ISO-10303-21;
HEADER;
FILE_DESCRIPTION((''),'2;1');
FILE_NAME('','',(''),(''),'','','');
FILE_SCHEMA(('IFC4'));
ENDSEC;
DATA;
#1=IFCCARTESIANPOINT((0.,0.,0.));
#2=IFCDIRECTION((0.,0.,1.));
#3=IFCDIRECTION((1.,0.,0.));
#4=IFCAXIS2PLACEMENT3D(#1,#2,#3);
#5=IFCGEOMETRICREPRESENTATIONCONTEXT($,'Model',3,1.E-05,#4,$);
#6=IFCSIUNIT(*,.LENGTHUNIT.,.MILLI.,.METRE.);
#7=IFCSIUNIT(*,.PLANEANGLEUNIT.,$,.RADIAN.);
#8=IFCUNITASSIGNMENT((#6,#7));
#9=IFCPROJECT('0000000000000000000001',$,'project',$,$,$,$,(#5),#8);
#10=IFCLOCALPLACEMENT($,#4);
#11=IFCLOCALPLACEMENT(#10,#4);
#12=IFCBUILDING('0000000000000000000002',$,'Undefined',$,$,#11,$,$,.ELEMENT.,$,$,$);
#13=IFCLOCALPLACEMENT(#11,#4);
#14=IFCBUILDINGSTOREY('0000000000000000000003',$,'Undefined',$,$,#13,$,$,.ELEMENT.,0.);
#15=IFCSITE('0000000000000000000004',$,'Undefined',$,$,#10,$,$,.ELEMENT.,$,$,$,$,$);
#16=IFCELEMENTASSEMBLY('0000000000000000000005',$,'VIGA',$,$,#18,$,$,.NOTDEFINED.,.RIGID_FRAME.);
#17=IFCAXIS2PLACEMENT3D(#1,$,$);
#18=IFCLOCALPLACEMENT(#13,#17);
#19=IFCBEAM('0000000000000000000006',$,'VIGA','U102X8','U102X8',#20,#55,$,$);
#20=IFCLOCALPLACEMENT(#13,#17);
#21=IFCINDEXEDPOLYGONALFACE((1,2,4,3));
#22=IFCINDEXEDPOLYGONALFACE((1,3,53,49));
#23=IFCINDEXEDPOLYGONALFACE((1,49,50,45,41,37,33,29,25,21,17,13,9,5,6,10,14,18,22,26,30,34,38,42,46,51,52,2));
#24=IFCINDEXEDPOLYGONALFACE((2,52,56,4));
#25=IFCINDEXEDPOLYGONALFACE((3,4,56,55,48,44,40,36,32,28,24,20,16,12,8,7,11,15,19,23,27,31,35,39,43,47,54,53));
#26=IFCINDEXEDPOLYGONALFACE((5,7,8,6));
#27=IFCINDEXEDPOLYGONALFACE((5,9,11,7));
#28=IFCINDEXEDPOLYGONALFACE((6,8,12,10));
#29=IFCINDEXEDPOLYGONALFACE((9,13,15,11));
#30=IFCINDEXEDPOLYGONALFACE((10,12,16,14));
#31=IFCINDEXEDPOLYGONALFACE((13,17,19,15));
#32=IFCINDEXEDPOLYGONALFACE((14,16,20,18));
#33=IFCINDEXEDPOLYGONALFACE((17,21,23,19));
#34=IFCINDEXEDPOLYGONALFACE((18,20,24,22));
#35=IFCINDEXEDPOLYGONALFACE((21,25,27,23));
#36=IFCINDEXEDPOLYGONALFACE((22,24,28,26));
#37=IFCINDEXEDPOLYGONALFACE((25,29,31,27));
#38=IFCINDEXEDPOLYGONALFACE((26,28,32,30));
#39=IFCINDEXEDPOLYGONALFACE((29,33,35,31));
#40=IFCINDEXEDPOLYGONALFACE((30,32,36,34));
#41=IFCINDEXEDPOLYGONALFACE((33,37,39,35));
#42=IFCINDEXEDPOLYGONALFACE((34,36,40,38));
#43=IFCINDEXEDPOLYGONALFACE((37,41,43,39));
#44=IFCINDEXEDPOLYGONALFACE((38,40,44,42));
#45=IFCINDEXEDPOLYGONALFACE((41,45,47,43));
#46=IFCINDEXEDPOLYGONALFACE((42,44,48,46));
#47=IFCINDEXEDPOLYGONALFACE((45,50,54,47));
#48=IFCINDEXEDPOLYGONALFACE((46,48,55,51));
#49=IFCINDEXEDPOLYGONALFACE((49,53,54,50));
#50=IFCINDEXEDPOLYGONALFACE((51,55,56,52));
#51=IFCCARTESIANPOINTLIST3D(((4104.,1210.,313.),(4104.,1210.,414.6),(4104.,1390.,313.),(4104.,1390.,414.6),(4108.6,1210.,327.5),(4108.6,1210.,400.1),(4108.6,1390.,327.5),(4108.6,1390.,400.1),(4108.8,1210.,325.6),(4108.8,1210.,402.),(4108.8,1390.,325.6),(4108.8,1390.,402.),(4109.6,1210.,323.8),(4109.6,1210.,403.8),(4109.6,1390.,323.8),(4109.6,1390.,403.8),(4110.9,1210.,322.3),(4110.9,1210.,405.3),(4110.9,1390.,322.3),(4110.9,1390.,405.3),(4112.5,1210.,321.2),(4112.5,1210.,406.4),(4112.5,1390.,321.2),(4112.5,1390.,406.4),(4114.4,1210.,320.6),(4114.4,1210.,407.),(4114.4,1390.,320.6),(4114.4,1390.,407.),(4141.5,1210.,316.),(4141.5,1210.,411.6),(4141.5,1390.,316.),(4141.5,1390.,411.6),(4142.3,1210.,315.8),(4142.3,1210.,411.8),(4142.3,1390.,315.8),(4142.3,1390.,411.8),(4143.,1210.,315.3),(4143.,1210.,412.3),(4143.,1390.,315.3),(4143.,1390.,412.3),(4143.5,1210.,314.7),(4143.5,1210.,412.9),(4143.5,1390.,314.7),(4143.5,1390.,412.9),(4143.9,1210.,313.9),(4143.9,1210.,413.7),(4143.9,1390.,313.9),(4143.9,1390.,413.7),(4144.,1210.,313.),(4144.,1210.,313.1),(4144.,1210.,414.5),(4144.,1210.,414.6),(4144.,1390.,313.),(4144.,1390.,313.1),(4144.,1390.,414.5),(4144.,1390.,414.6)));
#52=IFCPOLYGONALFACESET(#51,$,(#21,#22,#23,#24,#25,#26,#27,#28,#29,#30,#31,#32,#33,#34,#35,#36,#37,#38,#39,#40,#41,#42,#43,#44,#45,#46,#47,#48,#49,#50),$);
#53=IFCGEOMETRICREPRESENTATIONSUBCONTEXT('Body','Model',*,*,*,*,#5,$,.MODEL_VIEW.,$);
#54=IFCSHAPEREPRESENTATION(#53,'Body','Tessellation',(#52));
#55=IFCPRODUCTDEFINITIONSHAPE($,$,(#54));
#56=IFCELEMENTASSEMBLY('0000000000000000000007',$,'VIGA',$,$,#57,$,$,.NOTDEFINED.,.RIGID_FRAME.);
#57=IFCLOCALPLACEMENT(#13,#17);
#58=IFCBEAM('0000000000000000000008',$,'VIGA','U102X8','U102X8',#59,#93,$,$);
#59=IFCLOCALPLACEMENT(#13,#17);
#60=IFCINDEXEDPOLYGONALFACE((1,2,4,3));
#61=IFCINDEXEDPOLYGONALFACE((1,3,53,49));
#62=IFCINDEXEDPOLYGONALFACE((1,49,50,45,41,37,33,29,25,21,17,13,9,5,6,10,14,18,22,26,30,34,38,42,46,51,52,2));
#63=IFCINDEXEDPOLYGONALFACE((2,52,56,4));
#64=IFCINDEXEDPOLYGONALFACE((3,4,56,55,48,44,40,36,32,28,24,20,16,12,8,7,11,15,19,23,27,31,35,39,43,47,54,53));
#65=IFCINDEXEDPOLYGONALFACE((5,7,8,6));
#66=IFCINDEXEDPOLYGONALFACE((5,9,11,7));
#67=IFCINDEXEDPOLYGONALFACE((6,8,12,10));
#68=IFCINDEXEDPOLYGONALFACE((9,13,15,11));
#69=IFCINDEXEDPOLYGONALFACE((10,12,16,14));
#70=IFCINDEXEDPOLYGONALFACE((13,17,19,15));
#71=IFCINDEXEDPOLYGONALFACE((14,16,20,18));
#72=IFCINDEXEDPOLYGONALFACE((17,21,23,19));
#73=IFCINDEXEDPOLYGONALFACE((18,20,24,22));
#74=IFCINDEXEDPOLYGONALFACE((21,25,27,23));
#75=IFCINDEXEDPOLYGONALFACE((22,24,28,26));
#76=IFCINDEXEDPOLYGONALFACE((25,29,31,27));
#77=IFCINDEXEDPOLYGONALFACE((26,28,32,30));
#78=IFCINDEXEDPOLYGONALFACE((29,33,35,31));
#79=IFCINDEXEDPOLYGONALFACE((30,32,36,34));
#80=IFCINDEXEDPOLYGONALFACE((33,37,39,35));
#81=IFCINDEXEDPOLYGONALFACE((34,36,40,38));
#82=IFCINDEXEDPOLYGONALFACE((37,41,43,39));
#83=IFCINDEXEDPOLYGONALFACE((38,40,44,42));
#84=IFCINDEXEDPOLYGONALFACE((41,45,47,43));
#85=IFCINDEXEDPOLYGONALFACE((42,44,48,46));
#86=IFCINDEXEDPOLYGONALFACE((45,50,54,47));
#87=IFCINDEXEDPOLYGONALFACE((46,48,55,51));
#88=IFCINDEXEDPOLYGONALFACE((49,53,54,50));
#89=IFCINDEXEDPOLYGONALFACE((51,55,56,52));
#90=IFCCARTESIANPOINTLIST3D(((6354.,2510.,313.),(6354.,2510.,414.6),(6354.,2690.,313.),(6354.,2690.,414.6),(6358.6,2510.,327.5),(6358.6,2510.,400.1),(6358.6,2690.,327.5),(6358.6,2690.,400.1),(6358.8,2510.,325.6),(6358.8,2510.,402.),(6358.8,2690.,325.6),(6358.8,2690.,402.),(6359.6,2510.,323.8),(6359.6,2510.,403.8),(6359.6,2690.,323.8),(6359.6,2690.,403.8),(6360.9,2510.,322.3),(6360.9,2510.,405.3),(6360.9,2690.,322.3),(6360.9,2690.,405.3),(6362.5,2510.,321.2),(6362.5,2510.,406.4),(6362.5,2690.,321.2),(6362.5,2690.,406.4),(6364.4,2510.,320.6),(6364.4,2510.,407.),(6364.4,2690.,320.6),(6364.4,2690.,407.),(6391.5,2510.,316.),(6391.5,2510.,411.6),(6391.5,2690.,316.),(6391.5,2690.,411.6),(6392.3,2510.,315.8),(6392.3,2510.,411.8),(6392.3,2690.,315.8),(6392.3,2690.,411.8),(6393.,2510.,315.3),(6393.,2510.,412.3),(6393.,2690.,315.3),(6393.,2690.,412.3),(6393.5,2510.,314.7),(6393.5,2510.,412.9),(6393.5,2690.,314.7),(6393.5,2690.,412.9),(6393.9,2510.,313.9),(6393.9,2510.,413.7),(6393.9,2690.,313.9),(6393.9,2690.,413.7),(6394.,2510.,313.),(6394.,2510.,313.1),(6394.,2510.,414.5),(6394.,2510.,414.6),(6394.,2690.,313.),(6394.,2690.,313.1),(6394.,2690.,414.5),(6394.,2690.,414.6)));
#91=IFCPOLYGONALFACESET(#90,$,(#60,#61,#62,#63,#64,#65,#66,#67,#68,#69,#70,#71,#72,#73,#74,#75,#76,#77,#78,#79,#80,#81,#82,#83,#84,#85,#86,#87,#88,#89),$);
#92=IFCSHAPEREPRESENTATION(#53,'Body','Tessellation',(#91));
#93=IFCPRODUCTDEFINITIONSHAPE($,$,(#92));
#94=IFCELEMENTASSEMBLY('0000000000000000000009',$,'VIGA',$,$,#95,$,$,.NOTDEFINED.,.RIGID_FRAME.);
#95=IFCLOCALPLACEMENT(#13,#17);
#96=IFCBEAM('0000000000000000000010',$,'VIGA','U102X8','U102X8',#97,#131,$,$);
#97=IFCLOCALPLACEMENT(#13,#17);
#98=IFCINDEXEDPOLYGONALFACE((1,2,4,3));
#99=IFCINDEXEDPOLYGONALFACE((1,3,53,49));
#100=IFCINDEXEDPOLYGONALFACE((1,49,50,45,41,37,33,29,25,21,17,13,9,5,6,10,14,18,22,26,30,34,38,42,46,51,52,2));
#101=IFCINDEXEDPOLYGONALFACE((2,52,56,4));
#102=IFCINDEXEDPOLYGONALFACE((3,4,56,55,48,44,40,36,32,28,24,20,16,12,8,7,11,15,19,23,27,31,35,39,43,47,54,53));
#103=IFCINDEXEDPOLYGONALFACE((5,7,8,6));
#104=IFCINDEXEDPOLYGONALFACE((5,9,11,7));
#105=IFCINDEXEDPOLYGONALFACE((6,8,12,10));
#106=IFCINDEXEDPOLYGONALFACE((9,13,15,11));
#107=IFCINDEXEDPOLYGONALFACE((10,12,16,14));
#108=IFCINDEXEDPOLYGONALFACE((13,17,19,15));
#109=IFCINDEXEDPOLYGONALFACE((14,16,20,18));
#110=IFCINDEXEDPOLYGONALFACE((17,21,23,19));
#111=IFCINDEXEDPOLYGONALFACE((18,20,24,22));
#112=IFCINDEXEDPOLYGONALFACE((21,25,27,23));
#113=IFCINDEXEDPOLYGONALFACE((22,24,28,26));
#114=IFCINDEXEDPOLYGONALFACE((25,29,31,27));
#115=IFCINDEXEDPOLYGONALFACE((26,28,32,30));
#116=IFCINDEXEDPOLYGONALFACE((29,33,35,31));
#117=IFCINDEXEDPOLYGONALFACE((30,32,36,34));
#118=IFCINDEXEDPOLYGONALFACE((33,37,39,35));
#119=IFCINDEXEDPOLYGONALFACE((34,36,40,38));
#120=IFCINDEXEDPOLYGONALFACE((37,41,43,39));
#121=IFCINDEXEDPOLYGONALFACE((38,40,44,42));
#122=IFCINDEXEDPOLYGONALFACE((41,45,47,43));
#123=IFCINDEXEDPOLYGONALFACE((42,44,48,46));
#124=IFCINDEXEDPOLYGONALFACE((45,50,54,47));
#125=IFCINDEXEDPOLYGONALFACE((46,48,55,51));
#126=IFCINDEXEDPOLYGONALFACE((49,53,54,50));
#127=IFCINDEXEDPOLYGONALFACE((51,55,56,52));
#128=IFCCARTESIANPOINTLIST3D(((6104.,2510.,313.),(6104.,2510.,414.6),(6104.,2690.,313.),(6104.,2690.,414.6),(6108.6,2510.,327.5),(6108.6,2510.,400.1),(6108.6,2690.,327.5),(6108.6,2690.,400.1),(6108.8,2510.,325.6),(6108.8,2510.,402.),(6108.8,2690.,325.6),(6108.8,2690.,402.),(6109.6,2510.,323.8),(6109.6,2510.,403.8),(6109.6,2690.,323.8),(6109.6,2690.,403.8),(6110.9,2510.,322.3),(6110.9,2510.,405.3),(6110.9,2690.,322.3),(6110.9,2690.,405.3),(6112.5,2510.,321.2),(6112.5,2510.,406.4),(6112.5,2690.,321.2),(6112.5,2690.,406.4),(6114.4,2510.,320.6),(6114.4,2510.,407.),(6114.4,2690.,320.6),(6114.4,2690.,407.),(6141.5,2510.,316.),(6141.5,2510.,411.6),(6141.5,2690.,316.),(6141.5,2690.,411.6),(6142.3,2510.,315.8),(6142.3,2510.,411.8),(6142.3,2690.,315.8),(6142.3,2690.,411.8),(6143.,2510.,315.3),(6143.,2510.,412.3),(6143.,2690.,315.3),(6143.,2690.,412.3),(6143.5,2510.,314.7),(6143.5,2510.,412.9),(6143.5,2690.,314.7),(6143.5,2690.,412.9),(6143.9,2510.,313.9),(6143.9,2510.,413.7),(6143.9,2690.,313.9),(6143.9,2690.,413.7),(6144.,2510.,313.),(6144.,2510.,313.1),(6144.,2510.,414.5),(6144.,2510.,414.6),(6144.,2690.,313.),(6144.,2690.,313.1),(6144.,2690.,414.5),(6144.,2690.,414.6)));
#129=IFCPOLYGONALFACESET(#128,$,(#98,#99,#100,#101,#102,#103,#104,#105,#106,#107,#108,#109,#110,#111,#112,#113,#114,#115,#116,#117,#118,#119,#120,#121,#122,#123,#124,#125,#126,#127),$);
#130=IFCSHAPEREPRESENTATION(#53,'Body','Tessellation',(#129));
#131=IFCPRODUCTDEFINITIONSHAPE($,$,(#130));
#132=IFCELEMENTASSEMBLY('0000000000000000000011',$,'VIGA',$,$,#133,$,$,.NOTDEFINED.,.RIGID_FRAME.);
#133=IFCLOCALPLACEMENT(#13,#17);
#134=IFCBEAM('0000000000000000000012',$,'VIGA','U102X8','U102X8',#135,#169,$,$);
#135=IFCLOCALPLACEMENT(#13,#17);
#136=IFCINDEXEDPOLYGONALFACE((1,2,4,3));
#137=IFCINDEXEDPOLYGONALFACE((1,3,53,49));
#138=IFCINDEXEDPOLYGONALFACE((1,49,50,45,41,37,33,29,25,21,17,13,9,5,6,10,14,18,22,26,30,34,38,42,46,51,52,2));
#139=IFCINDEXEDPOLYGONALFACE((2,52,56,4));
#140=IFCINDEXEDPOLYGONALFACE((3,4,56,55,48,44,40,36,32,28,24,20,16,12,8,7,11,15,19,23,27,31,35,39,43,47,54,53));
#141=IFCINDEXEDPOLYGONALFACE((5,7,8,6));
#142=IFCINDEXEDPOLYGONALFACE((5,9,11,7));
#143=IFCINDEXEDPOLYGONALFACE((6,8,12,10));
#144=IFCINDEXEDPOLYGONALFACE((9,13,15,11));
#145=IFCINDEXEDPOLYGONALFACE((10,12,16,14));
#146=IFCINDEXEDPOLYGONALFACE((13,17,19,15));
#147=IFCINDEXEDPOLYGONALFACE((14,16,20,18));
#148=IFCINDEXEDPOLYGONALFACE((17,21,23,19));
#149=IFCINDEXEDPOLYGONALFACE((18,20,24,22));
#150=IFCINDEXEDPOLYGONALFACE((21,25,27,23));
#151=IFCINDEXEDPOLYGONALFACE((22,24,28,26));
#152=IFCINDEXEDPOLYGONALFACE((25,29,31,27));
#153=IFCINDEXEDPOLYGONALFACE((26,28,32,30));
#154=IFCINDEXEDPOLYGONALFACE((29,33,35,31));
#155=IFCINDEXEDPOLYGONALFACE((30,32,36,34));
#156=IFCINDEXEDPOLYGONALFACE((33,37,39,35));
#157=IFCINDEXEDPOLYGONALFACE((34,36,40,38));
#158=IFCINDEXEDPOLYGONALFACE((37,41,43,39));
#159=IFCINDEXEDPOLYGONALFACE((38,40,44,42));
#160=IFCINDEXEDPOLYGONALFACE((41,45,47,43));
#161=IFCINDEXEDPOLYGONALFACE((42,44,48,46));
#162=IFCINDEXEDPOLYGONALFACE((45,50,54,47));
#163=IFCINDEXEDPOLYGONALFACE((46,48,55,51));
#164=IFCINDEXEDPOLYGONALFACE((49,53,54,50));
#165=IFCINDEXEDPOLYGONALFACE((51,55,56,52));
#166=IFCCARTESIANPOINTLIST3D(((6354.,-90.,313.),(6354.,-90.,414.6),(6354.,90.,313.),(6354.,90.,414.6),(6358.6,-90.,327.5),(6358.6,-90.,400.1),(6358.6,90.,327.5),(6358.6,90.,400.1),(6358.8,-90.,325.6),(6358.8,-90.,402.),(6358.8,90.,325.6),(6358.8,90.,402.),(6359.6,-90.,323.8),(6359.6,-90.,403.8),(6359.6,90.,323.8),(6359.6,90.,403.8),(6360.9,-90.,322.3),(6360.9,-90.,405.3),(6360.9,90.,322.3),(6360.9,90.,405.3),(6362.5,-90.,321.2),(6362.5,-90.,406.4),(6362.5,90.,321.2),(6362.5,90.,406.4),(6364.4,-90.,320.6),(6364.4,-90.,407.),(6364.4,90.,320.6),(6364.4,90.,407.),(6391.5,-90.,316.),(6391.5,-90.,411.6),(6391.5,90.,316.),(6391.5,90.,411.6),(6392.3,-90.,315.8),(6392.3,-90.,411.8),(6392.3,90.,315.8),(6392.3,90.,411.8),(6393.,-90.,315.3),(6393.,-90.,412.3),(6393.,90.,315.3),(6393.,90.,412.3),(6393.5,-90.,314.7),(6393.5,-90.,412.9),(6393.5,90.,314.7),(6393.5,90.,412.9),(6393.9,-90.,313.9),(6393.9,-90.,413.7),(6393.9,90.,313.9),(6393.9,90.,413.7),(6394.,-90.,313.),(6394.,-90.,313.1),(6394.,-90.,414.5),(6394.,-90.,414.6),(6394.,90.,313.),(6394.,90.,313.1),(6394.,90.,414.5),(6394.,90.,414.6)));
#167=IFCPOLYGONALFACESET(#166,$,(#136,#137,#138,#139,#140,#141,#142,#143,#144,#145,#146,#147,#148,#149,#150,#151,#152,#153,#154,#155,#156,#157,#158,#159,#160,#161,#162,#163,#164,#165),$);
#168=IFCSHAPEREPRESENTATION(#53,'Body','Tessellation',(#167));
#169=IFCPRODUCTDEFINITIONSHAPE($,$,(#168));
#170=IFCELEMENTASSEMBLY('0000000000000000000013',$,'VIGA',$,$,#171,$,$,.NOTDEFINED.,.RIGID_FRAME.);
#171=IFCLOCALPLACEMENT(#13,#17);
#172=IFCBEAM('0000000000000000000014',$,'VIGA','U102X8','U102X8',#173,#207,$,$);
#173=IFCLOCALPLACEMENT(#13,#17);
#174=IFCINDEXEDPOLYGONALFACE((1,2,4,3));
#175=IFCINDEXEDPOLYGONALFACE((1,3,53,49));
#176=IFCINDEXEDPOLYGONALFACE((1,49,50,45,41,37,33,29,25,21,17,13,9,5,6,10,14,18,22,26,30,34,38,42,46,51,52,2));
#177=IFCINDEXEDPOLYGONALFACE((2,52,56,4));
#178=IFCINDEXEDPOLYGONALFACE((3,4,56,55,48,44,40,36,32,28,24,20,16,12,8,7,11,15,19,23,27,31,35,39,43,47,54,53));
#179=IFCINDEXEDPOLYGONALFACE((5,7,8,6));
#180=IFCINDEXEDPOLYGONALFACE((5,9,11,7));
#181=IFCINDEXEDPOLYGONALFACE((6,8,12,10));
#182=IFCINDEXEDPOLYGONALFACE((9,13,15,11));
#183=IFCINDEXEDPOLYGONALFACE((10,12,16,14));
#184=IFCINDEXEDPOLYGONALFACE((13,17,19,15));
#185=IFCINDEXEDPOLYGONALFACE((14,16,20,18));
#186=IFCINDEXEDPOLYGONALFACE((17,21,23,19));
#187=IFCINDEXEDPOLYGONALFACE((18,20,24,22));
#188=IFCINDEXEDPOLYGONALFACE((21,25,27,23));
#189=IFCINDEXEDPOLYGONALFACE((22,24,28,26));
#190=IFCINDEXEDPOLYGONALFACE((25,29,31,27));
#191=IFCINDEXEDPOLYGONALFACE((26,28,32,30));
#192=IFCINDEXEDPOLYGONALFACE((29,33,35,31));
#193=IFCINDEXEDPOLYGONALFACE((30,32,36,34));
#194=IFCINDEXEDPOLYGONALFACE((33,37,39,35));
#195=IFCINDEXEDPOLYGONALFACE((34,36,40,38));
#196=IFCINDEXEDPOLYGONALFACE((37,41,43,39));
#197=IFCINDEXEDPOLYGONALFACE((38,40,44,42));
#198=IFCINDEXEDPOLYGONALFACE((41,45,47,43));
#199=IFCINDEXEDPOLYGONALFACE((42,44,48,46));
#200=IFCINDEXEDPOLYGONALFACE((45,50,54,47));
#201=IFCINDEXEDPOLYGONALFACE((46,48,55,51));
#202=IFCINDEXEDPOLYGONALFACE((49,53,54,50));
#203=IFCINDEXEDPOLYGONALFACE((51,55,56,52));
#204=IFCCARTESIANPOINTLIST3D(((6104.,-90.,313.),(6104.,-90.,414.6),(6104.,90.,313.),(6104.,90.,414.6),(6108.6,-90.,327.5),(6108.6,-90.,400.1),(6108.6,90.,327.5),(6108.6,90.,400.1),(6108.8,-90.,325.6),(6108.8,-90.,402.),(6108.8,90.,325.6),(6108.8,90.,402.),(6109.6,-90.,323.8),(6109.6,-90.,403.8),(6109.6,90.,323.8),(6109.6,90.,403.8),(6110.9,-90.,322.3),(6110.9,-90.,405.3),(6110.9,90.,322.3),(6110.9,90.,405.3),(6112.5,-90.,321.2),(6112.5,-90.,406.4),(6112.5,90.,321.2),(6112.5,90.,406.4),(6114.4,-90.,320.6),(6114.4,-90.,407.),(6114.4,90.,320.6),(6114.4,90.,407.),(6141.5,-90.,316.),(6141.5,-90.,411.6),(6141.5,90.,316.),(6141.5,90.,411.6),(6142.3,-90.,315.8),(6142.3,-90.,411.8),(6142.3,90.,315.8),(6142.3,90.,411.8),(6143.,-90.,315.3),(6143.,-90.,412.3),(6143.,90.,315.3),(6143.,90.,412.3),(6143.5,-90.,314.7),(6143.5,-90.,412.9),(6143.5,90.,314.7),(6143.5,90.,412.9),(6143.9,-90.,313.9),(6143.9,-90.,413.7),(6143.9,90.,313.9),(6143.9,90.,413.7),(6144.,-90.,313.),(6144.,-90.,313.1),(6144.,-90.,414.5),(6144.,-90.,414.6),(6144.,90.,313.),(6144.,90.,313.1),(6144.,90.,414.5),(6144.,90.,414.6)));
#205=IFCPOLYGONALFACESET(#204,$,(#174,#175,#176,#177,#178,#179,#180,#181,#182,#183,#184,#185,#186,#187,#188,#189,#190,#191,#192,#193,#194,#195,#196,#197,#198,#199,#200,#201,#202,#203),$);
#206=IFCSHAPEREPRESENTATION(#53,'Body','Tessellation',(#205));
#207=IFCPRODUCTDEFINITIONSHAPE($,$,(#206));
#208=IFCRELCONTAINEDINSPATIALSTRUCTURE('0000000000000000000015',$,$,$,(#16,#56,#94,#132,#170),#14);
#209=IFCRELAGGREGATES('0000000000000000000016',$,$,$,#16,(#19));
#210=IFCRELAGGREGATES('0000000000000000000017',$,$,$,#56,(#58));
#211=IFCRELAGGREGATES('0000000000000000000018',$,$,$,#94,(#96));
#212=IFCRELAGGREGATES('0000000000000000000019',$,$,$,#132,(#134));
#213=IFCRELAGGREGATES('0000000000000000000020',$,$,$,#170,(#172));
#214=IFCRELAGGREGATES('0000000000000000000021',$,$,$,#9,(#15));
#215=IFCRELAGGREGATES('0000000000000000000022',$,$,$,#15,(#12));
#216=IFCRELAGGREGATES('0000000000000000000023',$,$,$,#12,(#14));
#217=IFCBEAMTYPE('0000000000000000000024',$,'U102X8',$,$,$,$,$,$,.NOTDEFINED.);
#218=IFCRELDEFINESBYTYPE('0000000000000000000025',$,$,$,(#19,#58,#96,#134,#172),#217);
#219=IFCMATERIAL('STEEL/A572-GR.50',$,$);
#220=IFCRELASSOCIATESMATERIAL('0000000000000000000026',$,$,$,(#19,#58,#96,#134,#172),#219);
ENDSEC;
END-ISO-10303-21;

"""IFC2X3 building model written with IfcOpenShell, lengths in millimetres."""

from ifc_helpers import new_model, si_unit, frame, origin_with_axes, origin_2d_with_axis, place, context, subcontext, project, spatial, u_section, extrude, material, type_object, element, aggregate, save


model = new_model("IFC2X3")

# Units and contexts
model_context = context("Model", 3, precision=1e-05, world=origin_with_axes())
body_context = subcontext(model_context, "Body", "Model", "MODEL_VIEW")
ifc_project = project(units=[si_unit("LENGTHUNIT", "METRE", prefix="MILLI"), si_unit("PLANEANGLEUNIT", "RADIAN")], contexts=[model_context])

# Site, building, storey
site_placement = place(None, origin_with_axes())
site = spatial("IfcSite", under=ifc_project, at=site_placement, Name="Undefined", CompositionType="ELEMENT")
building_placement = place(site_placement, origin_with_axes())
building = spatial("IfcBuilding", under=site, at=building_placement, Name="Undefined", CompositionType="ELEMENT")
storey_placement = place(building_placement, origin_with_axes())
storey = spatial("IfcBuildingStorey", under=building, at=storey_placement, Name="Undefined", CompositionType="ELEMENT", Elevation=0.0)

# Element assemblies, beams
ifc_material = material(Name="STEEL/A572-GR.50")
beam_type = type_object("IfcBeamType", Name="U102X8", PredefinedType="NOTDEFINED")
assembly_1_placement = place(storey_placement, origin_with_axes())
assembly_1 = element("IfcElementAssembly", 1, at=assembly_1_placement, inside=storey, Name="VIGA", AssemblyPlace="NOTDEFINED", PredefinedType="RIGID_FRAME")
beam_1_placement = place(assembly_1_placement, frame((4124.0, 1210.0, 363.8), z_axis=(0.0, 0.0, 1.0), x_axis=(0.0, 1.0, 0.0)))
beam_1 = element("IfcBeam", 2, at=beam_1_placement, type_object=beam_type, material=ifc_material, Name="VIGA", Description="U102X8", ObjectType="U102X8", context=body_context, shape_type="SweptSolid", body=[
    extrude(u_section(Depth=101.6, FlangeWidth=40.0, WebThickness=4.6, FlangeThickness=6.0, FilletRadius=7.0, EdgeRadius=3.0, FlangeSlope=0.16839, at=origin_2d_with_axis()), frame((180.0, 0.0, 0.0), z_axis=(-1.0, 0.0, 0.0), x_axis=(0.0, -1.0, 0.0)), (0.0, 0.0, 1.0), 180.0),
])
aggregate(assembly_1, [beam_1])
assembly_2_placement = place(storey_placement, origin_with_axes())
assembly_2 = element("IfcElementAssembly", 3, at=assembly_2_placement, inside=storey, Name="VIGA", AssemblyPlace="NOTDEFINED", PredefinedType="RIGID_FRAME")
beam_2_placement = place(assembly_2_placement, frame((6374.0, 2510.0, 363.8), z_axis=(0.0, 0.0, 1.0), x_axis=(0.0, 1.0, 0.0)))
beam_2 = element("IfcBeam", 4, at=beam_2_placement, type_object=beam_type, material=ifc_material, Name="VIGA", Description="U102X8", ObjectType="U102X8", context=body_context, shape_type="SweptSolid", body=[
    extrude(u_section(Depth=101.6, FlangeWidth=40.0, WebThickness=4.6, FlangeThickness=6.0, FilletRadius=7.0, EdgeRadius=3.0, FlangeSlope=0.16839, at=origin_2d_with_axis()), frame((180.0, 0.0, 0.0), z_axis=(-1.0, 0.0, 0.0), x_axis=(0.0, -1.0, 0.0)), (0.0, 0.0, 1.0), 180.0),
])
aggregate(assembly_2, [beam_2])
assembly_3_placement = place(storey_placement, origin_with_axes())
assembly_3 = element("IfcElementAssembly", 5, at=assembly_3_placement, inside=storey, Name="VIGA", AssemblyPlace="NOTDEFINED", PredefinedType="RIGID_FRAME")
beam_3_placement = place(assembly_3_placement, frame((6124.0, 2510.0, 363.8), z_axis=(0.0, 0.0, 1.0), x_axis=(0.0, 1.0, 0.0)))
beam_3 = element("IfcBeam", 6, at=beam_3_placement, type_object=beam_type, material=ifc_material, Name="VIGA", Description="U102X8", ObjectType="U102X8", context=body_context, shape_type="SweptSolid", body=[
    extrude(u_section(Depth=101.6, FlangeWidth=40.0, WebThickness=4.6, FlangeThickness=6.0, FilletRadius=7.0, EdgeRadius=3.0, FlangeSlope=0.16839, at=origin_2d_with_axis()), frame((180.0, 0.0, 0.0), z_axis=(-1.0, 0.0, 0.0), x_axis=(0.0, -1.0, 0.0)), (0.0, 0.0, 1.0), 180.0),
])
aggregate(assembly_3, [beam_3])
assembly_4_placement = place(storey_placement, origin_with_axes())
assembly_4 = element("IfcElementAssembly", 7, at=assembly_4_placement, inside=storey, Name="VIGA", AssemblyPlace="NOTDEFINED", PredefinedType="RIGID_FRAME")
beam_4_placement = place(assembly_4_placement, frame((6374.0, -90.0, 363.8), z_axis=(0.0, 0.0, 1.0), x_axis=(0.0, 1.0, 0.0)))
beam_4 = element("IfcBeam", 8, at=beam_4_placement, type_object=beam_type, material=ifc_material, Name="VIGA", Description="U102X8", ObjectType="U102X8", context=body_context, shape_type="SweptSolid", body=[
    extrude(u_section(Depth=101.6, FlangeWidth=40.0, WebThickness=4.6, FlangeThickness=6.0, FilletRadius=7.0, EdgeRadius=3.0, FlangeSlope=0.16839, at=origin_2d_with_axis()), frame((180.0, 0.0, 0.0), z_axis=(-1.0, 0.0, 0.0), x_axis=(0.0, -1.0, 0.0)), (0.0, 0.0, 1.0), 180.0),
])
aggregate(assembly_4, [beam_4])
assembly_5_placement = place(storey_placement, origin_with_axes())
assembly_5 = element("IfcElementAssembly", 9, at=assembly_5_placement, inside=storey, Name="VIGA", AssemblyPlace="NOTDEFINED", PredefinedType="RIGID_FRAME")
beam_5_placement = place(assembly_5_placement, frame((6124.0, -90.0, 363.8), z_axis=(0.0, 0.0, 1.0), x_axis=(0.0, 1.0, 0.0)))
beam_5 = element("IfcBeam", 10, at=beam_5_placement, type_object=beam_type, material=ifc_material, Name="VIGA", Description="U102X8", ObjectType="U102X8", context=body_context, shape_type="SweptSolid", body=[
    extrude(u_section(Depth=101.6, FlangeWidth=40.0, WebThickness=4.6, FlangeThickness=6.0, FilletRadius=7.0, EdgeRadius=3.0, FlangeSlope=0.16839, at=origin_2d_with_axis()), frame((180.0, 0.0, 0.0), z_axis=(-1.0, 0.0, 0.0), x_axis=(0.0, -1.0, 0.0)), (0.0, 0.0, 1.0), 180.0),
])
aggregate(assembly_5, [beam_5])

save(model, "model.ifc")
